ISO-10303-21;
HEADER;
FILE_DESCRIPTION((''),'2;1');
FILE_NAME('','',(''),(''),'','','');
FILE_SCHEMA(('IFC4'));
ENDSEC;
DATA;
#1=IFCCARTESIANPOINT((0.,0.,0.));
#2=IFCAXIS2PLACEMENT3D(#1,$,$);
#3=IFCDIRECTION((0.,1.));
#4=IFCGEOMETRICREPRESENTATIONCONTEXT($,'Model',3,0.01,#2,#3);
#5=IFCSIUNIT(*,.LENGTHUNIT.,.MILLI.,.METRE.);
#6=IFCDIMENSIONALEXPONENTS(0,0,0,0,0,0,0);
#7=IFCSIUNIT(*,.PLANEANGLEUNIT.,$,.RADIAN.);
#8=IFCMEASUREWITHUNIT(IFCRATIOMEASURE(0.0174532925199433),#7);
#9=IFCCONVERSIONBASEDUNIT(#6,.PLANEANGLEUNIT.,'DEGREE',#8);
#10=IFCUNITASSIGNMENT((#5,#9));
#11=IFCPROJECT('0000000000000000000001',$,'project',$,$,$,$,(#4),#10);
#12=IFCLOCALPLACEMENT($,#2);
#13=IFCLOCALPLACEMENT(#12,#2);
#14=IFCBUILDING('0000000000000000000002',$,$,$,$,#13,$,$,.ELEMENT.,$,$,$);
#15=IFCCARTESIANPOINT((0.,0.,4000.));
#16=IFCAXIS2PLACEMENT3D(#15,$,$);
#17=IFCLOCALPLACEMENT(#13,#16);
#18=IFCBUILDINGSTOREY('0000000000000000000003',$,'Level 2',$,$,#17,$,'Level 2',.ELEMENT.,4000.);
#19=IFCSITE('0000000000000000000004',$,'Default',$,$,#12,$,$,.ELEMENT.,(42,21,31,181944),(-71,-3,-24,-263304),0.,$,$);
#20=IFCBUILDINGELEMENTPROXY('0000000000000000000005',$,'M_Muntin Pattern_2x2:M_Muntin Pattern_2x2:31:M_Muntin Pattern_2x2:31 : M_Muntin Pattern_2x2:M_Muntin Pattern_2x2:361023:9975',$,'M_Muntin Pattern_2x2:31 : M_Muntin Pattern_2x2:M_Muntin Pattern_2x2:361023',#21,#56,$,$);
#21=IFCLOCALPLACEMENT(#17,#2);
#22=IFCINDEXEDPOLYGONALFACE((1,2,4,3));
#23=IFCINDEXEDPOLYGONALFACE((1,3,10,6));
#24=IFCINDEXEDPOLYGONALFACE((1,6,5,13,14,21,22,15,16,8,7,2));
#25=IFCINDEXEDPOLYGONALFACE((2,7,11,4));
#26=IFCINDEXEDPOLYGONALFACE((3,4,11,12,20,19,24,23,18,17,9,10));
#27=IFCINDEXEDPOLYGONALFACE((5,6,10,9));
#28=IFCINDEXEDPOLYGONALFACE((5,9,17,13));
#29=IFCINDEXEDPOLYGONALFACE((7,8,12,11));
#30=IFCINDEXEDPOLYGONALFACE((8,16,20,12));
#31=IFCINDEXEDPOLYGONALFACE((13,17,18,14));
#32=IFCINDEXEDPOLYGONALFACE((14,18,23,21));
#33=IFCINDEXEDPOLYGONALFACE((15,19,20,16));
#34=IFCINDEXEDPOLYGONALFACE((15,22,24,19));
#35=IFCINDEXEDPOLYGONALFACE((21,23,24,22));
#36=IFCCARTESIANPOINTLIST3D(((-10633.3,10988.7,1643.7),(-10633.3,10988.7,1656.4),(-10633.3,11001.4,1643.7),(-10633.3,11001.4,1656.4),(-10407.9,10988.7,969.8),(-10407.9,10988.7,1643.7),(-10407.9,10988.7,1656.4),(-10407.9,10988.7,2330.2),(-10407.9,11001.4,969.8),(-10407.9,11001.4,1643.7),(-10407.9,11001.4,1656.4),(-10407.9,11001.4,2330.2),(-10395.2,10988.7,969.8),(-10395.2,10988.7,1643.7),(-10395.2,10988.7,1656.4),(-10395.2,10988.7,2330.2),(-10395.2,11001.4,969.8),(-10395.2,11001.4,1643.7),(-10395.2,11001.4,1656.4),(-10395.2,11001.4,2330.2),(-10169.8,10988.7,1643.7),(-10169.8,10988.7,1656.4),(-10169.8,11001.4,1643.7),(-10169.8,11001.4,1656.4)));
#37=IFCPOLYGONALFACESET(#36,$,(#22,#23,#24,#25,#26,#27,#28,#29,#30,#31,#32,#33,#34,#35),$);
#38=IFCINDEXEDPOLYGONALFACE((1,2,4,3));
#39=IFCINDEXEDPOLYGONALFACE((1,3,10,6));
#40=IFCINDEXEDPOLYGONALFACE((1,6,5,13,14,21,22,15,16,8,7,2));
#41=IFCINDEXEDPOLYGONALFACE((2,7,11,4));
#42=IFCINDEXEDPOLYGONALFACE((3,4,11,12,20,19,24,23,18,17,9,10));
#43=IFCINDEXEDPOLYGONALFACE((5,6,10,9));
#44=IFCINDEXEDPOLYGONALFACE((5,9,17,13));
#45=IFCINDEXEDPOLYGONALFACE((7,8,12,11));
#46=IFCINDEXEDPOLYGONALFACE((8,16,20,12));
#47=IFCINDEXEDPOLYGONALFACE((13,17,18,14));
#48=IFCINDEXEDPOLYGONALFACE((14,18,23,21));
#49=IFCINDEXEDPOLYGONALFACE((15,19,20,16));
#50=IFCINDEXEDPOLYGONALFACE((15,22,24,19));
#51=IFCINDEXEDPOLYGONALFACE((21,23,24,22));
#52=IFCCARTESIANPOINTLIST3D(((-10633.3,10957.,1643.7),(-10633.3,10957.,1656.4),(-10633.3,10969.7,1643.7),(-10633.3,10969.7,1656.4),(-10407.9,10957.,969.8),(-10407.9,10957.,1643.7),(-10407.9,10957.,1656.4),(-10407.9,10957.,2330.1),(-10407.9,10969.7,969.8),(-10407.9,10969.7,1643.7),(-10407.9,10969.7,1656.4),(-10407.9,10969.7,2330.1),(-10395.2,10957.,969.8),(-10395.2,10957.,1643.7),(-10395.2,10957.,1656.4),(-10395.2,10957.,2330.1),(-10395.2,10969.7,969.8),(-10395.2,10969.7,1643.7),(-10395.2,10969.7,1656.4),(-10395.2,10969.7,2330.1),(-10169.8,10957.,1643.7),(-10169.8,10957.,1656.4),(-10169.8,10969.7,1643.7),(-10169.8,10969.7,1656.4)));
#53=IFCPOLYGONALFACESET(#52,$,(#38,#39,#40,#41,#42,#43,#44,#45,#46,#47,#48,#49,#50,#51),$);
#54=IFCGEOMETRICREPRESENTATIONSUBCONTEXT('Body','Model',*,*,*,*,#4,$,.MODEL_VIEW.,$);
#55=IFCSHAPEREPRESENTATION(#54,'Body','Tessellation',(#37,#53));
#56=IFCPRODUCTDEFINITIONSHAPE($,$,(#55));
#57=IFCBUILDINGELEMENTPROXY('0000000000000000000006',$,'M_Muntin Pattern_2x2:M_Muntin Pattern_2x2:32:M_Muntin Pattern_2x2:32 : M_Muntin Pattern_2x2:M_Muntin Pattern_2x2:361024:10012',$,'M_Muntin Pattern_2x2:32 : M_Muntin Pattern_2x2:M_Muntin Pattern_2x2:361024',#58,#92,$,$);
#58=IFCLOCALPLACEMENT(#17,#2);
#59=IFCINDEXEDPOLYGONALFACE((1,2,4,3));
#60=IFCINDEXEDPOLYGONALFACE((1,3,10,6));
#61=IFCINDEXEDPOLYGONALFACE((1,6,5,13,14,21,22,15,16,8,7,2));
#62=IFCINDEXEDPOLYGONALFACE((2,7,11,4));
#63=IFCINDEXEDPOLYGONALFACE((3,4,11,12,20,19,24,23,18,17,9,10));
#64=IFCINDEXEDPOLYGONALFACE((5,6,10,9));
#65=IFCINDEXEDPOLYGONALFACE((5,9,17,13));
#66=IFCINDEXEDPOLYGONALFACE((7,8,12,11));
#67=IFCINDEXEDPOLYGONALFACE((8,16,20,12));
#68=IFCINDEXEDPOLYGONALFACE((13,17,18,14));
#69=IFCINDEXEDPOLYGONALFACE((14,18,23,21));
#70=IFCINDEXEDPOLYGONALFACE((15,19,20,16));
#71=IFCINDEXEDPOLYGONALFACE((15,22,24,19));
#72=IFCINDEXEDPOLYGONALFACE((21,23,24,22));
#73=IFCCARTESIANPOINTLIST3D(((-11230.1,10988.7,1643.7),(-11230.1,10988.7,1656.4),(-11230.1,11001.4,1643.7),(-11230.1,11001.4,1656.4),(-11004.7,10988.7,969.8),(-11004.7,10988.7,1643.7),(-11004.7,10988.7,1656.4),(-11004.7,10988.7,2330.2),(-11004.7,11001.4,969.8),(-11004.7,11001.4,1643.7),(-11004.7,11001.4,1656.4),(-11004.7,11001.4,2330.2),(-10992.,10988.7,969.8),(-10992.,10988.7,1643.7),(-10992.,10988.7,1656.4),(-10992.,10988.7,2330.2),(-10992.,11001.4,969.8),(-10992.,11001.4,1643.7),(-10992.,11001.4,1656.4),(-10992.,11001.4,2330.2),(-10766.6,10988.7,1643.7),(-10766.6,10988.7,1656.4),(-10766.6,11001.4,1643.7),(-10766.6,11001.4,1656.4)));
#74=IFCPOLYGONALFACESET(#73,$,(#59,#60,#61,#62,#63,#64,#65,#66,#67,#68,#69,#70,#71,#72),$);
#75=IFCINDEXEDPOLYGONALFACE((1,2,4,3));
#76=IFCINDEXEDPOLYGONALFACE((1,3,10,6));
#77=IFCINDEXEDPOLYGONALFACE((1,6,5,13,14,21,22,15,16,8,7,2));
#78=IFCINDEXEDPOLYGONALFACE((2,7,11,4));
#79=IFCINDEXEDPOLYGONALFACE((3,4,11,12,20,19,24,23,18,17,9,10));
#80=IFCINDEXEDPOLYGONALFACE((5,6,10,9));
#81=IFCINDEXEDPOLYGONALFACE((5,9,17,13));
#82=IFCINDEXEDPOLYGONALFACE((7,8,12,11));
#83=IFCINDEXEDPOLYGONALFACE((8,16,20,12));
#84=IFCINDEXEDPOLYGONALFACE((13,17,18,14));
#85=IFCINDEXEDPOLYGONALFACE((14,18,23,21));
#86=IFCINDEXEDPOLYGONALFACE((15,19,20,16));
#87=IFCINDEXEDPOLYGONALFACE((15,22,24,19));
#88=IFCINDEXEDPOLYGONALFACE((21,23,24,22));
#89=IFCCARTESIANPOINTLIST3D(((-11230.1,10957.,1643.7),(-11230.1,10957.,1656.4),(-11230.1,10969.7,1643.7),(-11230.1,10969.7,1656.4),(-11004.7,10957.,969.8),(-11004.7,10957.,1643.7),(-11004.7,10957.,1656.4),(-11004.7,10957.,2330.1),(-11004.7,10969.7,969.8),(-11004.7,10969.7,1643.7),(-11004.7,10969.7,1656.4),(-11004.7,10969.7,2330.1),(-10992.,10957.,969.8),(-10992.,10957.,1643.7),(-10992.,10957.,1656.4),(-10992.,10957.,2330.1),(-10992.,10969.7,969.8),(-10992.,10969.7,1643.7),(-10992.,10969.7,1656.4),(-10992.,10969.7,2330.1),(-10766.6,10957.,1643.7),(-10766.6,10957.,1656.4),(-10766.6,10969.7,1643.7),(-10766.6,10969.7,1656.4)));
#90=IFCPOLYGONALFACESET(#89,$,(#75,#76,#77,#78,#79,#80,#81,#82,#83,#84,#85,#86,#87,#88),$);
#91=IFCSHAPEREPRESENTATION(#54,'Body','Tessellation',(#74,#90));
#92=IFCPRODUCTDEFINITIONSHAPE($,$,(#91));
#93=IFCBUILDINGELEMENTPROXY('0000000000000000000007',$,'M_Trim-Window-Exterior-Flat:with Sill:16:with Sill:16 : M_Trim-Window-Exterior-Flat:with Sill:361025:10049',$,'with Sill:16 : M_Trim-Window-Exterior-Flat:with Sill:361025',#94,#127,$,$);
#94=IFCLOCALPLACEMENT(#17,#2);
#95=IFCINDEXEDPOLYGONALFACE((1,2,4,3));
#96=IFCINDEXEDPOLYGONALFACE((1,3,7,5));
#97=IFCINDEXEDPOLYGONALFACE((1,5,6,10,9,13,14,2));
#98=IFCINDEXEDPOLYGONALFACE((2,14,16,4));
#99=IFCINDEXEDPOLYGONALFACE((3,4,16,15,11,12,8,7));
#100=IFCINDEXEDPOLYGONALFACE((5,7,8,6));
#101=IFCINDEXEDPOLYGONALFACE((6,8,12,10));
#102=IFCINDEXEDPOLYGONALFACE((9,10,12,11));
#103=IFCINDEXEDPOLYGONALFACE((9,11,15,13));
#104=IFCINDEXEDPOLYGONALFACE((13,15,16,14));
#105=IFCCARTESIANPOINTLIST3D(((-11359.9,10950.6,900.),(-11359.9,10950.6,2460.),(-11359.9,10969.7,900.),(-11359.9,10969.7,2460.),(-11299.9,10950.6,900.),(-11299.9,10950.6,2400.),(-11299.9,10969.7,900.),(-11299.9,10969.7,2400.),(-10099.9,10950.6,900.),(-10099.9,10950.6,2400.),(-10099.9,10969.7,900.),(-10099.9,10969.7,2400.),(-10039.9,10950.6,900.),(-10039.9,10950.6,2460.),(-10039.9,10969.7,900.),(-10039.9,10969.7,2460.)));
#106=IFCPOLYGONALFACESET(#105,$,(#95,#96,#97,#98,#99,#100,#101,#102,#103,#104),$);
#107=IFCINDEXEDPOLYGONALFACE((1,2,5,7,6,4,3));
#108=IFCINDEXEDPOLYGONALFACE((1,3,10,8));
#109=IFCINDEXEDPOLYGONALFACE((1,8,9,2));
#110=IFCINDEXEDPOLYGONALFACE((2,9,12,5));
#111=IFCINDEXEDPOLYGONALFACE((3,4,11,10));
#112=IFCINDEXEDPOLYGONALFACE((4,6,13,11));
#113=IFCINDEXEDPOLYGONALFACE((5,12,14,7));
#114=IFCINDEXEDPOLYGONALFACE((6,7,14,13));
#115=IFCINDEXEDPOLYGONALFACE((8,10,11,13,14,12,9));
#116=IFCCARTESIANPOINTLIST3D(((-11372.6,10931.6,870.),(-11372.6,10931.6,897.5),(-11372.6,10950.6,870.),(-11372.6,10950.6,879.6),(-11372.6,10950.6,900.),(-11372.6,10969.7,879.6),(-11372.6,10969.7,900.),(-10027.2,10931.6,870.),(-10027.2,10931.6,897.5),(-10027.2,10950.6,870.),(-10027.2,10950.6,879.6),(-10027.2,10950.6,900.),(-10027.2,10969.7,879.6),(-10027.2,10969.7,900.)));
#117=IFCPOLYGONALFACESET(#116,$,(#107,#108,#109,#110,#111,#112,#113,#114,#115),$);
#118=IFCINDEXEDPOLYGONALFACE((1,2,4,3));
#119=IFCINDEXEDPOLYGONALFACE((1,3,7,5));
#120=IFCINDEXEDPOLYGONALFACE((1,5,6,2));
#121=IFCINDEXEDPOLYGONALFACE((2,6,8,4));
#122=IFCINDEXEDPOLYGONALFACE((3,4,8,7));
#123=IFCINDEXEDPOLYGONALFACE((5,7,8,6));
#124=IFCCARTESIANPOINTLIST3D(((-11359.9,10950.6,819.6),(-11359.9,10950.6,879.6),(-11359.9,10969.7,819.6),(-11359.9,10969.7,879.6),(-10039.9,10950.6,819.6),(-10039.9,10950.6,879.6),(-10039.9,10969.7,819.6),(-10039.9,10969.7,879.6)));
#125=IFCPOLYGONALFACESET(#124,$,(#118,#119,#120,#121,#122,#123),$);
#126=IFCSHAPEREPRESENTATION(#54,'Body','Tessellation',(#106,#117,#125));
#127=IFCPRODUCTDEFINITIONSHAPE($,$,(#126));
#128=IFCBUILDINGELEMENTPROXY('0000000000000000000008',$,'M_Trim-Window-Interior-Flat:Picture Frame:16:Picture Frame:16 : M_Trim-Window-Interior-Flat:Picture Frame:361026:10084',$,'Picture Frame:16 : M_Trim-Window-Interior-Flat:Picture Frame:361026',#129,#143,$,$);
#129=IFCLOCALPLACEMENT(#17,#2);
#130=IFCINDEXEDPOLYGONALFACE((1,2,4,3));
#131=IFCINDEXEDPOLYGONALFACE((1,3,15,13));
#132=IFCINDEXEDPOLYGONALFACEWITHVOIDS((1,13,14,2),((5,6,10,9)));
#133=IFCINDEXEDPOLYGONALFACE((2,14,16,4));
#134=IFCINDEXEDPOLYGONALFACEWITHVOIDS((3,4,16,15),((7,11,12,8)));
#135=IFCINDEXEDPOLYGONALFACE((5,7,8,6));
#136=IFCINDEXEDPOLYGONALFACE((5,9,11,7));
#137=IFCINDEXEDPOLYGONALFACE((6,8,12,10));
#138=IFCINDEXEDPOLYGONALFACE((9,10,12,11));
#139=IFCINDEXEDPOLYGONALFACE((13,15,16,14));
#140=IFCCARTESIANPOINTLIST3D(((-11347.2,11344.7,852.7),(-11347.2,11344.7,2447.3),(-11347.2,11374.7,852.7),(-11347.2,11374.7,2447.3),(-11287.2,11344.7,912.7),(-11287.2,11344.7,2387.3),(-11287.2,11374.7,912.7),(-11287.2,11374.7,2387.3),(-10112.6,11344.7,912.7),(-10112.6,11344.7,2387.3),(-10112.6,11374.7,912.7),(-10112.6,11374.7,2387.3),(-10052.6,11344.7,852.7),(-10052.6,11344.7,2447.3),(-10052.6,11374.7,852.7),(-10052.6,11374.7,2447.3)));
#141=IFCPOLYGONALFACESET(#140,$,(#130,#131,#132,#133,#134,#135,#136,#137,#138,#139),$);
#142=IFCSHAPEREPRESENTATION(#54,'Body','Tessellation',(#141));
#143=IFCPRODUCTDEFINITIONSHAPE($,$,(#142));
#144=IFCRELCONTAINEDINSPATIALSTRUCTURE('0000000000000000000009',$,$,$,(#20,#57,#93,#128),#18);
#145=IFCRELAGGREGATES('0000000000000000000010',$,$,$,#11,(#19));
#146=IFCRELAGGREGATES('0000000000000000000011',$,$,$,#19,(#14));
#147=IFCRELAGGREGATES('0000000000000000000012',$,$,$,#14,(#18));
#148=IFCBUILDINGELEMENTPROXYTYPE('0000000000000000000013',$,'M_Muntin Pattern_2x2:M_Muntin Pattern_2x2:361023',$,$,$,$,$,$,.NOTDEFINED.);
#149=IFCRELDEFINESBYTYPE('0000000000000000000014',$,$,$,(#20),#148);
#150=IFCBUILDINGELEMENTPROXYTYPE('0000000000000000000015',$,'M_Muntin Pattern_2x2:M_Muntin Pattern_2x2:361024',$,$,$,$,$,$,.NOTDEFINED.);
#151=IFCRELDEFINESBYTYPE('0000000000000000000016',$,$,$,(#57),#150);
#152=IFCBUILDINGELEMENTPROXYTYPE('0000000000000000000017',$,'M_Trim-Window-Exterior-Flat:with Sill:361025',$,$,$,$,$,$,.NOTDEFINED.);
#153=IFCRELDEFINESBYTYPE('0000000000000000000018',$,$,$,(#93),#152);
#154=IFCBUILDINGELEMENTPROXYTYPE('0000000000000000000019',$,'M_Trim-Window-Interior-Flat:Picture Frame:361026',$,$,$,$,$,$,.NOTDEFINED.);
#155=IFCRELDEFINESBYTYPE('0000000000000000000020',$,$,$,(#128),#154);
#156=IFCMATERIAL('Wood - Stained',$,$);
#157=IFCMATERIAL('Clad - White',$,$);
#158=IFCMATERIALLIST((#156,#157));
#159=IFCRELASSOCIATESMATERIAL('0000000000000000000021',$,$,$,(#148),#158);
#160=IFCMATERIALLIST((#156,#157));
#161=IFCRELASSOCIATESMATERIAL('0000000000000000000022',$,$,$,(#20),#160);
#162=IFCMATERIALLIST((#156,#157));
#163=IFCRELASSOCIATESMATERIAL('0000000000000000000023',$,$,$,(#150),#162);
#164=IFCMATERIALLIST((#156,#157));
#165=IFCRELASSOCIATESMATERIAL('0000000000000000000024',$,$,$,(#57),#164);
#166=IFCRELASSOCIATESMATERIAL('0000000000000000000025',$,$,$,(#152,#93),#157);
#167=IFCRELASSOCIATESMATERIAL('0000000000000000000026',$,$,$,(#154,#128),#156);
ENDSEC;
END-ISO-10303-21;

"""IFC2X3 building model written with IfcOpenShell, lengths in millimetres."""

from ifc_helpers import new_model, entity, si_unit, converted_unit, direction, frame, frame_2d, origin, place, context, subcontext, project, spatial, polyline, rectangle, outline, extrude, source, transform, mapped, material, material_list, type_object, type_shapes, element, save


model = new_model("IFC2X3")

# Units and contexts
model_context = context("Model", 3, precision=0.01, world=origin(), true_north=direction((0.0, 1.0)))
body_context = subcontext(model_context, "Body", "Model", "MODEL_VIEW")
ifc_project = project(units=[si_unit("LENGTHUNIT", "METRE", prefix="MILLI"), converted_unit("PLANEANGLEUNIT", "DEGREE", entity("IfcRatioMeasure", 0.0174532925199433), si_unit("PLANEANGLEUNIT", "RADIAN"), dimensions=[0, 0, 0, 0, 0, 0, 0])], contexts=[model_context])

# Site, building, storey
site_placement = place(None, origin())
site = spatial("IfcSite", under=ifc_project, at=site_placement, Name="Default", CompositionType="ELEMENT", RefLatitude=(42, 21, 31, 181944), RefLongitude=(-71, -3, -24, -263304), RefElevation=0.0)
building_placement = place(site_placement, origin())
building = spatial("IfcBuilding", under=site, at=building_placement, CompositionType="ELEMENT")
storey_placement = place(building_placement, frame((0.0, 0.0, 4000.0)))
storey = spatial("IfcBuildingStorey", under=building, at=storey_placement, Name="Level 2", LongName="Level 2", CompositionType="ELEMENT", Elevation=4000.0)

# Building element proxies
ifc_material_1 = material(Name="Wood - Stained")
ifc_material_2 = material(Name="Clad - White")
ifc_material_list_1 = material_list([ifc_material_1, ifc_material_2])
ifc_material_list_2 = material_list([ifc_material_1, ifc_material_2])
building_element_proxy_type_1 = type_object("IfcBuildingElementProxyType", Name="M_Muntin Pattern_2x2:M_Muntin Pattern_2x2:361023", PredefinedType="NOTDEFINED", material=ifc_material_list_2)
shared_shape_1 = source(origin(), body_context, "Body", "SweptSolid", [
    extrude(outline(polyline([(-680.2, 6.4), (-680.2, -6.3), (-6.4, -6.3), (-6.4, -231.7), (6.3, -231.7), (6.3, -6.3), (680.2, -6.3), (680.2, 6.4), (6.3, 6.4), (6.3, 231.7), (-6.4, 231.7), (-6.4, 6.4), (-680.2, 6.4)])), frame((-10401.5, 10988.7, 5650.0), z_axis=(0.0, -1.0, 0.0), x_axis=(0.0, 0.0, -1.0)), (0.0, 0.0, -1.0), 12.7),
    extrude(outline(polyline([(-680.1, 6.4), (-680.1, -6.3), (-6.4, -6.3), (-6.4, -231.7), (6.3, -231.7), (6.3, -6.3), (680.2, -6.3), (680.2, 6.4), (6.3, 6.4), (6.3, 231.7), (-6.4, 231.7), (-6.4, 6.4), (-680.1, 6.4)])), frame((-10401.5, 10957.0, 5650.0), z_axis=(0.0, -1.0, 0.0), x_axis=(0.0, 0.0, -1.0)), (0.0, 0.0, -1.0), 12.7),
])
type_shapes(building_element_proxy_type_1, [shared_shape_1])
proxy_1_placement = place(storey_placement, frame((0.0, 0.0, -4000.0)))
element("IfcBuildingElementProxy", 1, at=proxy_1_placement, inside=storey, type_object=building_element_proxy_type_1, material=ifc_material_list_1, Name="M_Muntin Pattern_2x2:M_Muntin Pattern_2x2:31:M_Muntin Pattern_2x2:31 : M_Muntin Pattern_2x2:M_Muntin Pattern_2x2:361023:9975", ObjectType="M_Muntin Pattern_2x2:31 : M_Muntin Pattern_2x2:M_Muntin Pattern_2x2:361023", context=body_context, shape_type="MappedRepresentation", body=[
    mapped(shared_shape_1, transform((0.0, 0.0, 0.0), scale=1.0)),
])
ifc_material_list_3 = material_list([ifc_material_1, ifc_material_2])
ifc_material_list_4 = material_list([ifc_material_1, ifc_material_2])
building_element_proxy_type_2 = type_object("IfcBuildingElementProxyType", Name="M_Muntin Pattern_2x2:M_Muntin Pattern_2x2:361024", PredefinedType="NOTDEFINED", material=ifc_material_list_4)
shared_shape_2 = source(origin(), body_context, "Body", "SweptSolid", [
    extrude(outline(polyline([(-6.4, -680.1), (6.3, -680.1), (6.3, -6.4), (231.7, -6.4), (231.7, 6.3), (6.3, 6.3), (6.3, 680.2), (-6.4, 680.2), (-6.4, 6.3), (-231.7, 6.3), (-231.7, -6.4), (-6.4, -6.4), (-6.4, -680.1)])), frame((-10998.4, 10988.7, 5650.0), z_axis=(0.0, 1.0, 0.0), x_axis=(1.0, 0.0, 0.0)), (0.0, 0.0, 1.0), 12.7),
    extrude(outline(polyline([(-6.4, -680.1), (6.3, -680.1), (6.3, -6.4), (231.7, -6.4), (231.7, 6.3), (6.3, 6.3), (6.3, 680.2), (-6.4, 680.2), (-6.4, 6.3), (-231.7, 6.3), (-231.7, -6.4), (-6.4, -6.4), (-6.4, -680.1)])), frame((-10998.4, 10957.0, 5650.0), z_axis=(0.0, 1.0, 0.0), x_axis=(1.0, 0.0, 0.0)), (0.0, 0.0, 1.0), 12.7),
])
type_shapes(building_element_proxy_type_2, [shared_shape_2])
proxy_2_placement = place(storey_placement, frame((0.0, 0.0, -4000.0)))
element("IfcBuildingElementProxy", 2, at=proxy_2_placement, inside=storey, type_object=building_element_proxy_type_2, material=ifc_material_list_3, Name="M_Muntin Pattern_2x2:M_Muntin Pattern_2x2:32:M_Muntin Pattern_2x2:32 : M_Muntin Pattern_2x2:M_Muntin Pattern_2x2:361024:10012", ObjectType="M_Muntin Pattern_2x2:32 : M_Muntin Pattern_2x2:M_Muntin Pattern_2x2:361024", context=body_context, shape_type="MappedRepresentation", body=[
    mapped(shared_shape_2, transform((0.0, 0.0, 0.0), scale=1.0)),
])
building_element_proxy_type_3 = type_object("IfcBuildingElementProxyType", Name="M_Trim-Window-Exterior-Flat:with Sill:361025", PredefinedType="NOTDEFINED", material=ifc_material_2)
shared_shape_3 = source(origin(), body_context, "Body", "SweptSolid", [
    extrude(outline(polyline([(-765.0, -660.0), (795.0, -660.0), (795.0, 660.0), (-765.0, 660.0), (-765.0, 600.0), (735.0, 600.0), (735.0, -600.0), (-765.0, -600.0), (-765.0, -660.0)])), frame((-10699.9, 10950.6, 5665.0), z_axis=(0.0, 1.0, 0.0), x_axis=(0.0, 0.0, 1.0)), (0.0, 0.0, 1.0), 19.1),
    extrude(outline(polyline([(-15.2, 0.0), (-15.2, -19.0), (12.3, -19.0), (14.8, 0.0), (14.8, 19.0), (-5.7, 19.0), (-5.7, 0.0), (-15.2, 0.0)])), frame((-11372.6, 10950.6, 4885.2), z_axis=(-1.0, 0.0, 0.0), x_axis=(0.0, 0.0, 1.0)), (0.0, 0.0, -1.0), 1345.4),
    extrude(rectangle(XDim=19.1, YDim=1320.0, at=frame_2d((0.0, 0.0), x_axis=(1.0, 0.0))), frame((-10699.9, 10960.1, 4819.6), z_axis=(0.0, 0.0, 1.0), x_axis=(0.0, 1.0, 0.0)), (0.0, 0.0, 1.0), 60.0),
])
type_shapes(building_element_proxy_type_3, [shared_shape_3])
proxy_3_placement = place(storey_placement, frame((0.0, 0.0, -4000.0)))
element("IfcBuildingElementProxy", 3, at=proxy_3_placement, inside=storey, type_object=building_element_proxy_type_3, material=ifc_material_2, Name="M_Trim-Window-Exterior-Flat:with Sill:16:with Sill:16 : M_Trim-Window-Exterior-Flat:with Sill:361025:10049", ObjectType="with Sill:16 : M_Trim-Window-Exterior-Flat:with Sill:361025", context=body_context, shape_type="MappedRepresentation", body=[
    mapped(shared_shape_3, transform((0.0, 0.0, 0.0), scale=1.0)),
])
building_element_proxy_type_4 = type_object("IfcBuildingElementProxyType", Name="M_Trim-Window-Interior-Flat:Picture Frame:361026", PredefinedType="NOTDEFINED", material=ifc_material_1)
shared_shape_4 = source(origin(), body_context, "Body", "SweptSolid", [
    extrude(outline(polyline([(-797.3, -647.3), (797.3, -647.3), (797.3, 647.3), (-797.3, 647.3), (-797.3, -647.3)]), holes=[polyline([(737.3, 587.3), (737.3, -587.3), (-737.3, -587.3), (-737.3, 587.3), (737.3, 587.3)])]), frame((-10699.9, 11344.7, 5650.0), z_axis=(0.0, 1.0, 0.0), x_axis=(0.0, 0.0, -1.0)), (0.0, 0.0, 1.0), 30.0),
])
type_shapes(building_element_proxy_type_4, [shared_shape_4])
proxy_4_placement = place(storey_placement, frame((0.0, 0.0, -4000.0)))
element("IfcBuildingElementProxy", 4, at=proxy_4_placement, inside=storey, type_object=building_element_proxy_type_4, material=ifc_material_1, Name="M_Trim-Window-Interior-Flat:Picture Frame:16:Picture Frame:16 : M_Trim-Window-Interior-Flat:Picture Frame:361026:10084", ObjectType="Picture Frame:16 : M_Trim-Window-Interior-Flat:Picture Frame:361026", context=body_context, shape_type="MappedRepresentation", body=[
    mapped(shared_shape_4, transform((0.0, 0.0, 0.0), scale=1.0)),
])

save(model, "model.ifc")
